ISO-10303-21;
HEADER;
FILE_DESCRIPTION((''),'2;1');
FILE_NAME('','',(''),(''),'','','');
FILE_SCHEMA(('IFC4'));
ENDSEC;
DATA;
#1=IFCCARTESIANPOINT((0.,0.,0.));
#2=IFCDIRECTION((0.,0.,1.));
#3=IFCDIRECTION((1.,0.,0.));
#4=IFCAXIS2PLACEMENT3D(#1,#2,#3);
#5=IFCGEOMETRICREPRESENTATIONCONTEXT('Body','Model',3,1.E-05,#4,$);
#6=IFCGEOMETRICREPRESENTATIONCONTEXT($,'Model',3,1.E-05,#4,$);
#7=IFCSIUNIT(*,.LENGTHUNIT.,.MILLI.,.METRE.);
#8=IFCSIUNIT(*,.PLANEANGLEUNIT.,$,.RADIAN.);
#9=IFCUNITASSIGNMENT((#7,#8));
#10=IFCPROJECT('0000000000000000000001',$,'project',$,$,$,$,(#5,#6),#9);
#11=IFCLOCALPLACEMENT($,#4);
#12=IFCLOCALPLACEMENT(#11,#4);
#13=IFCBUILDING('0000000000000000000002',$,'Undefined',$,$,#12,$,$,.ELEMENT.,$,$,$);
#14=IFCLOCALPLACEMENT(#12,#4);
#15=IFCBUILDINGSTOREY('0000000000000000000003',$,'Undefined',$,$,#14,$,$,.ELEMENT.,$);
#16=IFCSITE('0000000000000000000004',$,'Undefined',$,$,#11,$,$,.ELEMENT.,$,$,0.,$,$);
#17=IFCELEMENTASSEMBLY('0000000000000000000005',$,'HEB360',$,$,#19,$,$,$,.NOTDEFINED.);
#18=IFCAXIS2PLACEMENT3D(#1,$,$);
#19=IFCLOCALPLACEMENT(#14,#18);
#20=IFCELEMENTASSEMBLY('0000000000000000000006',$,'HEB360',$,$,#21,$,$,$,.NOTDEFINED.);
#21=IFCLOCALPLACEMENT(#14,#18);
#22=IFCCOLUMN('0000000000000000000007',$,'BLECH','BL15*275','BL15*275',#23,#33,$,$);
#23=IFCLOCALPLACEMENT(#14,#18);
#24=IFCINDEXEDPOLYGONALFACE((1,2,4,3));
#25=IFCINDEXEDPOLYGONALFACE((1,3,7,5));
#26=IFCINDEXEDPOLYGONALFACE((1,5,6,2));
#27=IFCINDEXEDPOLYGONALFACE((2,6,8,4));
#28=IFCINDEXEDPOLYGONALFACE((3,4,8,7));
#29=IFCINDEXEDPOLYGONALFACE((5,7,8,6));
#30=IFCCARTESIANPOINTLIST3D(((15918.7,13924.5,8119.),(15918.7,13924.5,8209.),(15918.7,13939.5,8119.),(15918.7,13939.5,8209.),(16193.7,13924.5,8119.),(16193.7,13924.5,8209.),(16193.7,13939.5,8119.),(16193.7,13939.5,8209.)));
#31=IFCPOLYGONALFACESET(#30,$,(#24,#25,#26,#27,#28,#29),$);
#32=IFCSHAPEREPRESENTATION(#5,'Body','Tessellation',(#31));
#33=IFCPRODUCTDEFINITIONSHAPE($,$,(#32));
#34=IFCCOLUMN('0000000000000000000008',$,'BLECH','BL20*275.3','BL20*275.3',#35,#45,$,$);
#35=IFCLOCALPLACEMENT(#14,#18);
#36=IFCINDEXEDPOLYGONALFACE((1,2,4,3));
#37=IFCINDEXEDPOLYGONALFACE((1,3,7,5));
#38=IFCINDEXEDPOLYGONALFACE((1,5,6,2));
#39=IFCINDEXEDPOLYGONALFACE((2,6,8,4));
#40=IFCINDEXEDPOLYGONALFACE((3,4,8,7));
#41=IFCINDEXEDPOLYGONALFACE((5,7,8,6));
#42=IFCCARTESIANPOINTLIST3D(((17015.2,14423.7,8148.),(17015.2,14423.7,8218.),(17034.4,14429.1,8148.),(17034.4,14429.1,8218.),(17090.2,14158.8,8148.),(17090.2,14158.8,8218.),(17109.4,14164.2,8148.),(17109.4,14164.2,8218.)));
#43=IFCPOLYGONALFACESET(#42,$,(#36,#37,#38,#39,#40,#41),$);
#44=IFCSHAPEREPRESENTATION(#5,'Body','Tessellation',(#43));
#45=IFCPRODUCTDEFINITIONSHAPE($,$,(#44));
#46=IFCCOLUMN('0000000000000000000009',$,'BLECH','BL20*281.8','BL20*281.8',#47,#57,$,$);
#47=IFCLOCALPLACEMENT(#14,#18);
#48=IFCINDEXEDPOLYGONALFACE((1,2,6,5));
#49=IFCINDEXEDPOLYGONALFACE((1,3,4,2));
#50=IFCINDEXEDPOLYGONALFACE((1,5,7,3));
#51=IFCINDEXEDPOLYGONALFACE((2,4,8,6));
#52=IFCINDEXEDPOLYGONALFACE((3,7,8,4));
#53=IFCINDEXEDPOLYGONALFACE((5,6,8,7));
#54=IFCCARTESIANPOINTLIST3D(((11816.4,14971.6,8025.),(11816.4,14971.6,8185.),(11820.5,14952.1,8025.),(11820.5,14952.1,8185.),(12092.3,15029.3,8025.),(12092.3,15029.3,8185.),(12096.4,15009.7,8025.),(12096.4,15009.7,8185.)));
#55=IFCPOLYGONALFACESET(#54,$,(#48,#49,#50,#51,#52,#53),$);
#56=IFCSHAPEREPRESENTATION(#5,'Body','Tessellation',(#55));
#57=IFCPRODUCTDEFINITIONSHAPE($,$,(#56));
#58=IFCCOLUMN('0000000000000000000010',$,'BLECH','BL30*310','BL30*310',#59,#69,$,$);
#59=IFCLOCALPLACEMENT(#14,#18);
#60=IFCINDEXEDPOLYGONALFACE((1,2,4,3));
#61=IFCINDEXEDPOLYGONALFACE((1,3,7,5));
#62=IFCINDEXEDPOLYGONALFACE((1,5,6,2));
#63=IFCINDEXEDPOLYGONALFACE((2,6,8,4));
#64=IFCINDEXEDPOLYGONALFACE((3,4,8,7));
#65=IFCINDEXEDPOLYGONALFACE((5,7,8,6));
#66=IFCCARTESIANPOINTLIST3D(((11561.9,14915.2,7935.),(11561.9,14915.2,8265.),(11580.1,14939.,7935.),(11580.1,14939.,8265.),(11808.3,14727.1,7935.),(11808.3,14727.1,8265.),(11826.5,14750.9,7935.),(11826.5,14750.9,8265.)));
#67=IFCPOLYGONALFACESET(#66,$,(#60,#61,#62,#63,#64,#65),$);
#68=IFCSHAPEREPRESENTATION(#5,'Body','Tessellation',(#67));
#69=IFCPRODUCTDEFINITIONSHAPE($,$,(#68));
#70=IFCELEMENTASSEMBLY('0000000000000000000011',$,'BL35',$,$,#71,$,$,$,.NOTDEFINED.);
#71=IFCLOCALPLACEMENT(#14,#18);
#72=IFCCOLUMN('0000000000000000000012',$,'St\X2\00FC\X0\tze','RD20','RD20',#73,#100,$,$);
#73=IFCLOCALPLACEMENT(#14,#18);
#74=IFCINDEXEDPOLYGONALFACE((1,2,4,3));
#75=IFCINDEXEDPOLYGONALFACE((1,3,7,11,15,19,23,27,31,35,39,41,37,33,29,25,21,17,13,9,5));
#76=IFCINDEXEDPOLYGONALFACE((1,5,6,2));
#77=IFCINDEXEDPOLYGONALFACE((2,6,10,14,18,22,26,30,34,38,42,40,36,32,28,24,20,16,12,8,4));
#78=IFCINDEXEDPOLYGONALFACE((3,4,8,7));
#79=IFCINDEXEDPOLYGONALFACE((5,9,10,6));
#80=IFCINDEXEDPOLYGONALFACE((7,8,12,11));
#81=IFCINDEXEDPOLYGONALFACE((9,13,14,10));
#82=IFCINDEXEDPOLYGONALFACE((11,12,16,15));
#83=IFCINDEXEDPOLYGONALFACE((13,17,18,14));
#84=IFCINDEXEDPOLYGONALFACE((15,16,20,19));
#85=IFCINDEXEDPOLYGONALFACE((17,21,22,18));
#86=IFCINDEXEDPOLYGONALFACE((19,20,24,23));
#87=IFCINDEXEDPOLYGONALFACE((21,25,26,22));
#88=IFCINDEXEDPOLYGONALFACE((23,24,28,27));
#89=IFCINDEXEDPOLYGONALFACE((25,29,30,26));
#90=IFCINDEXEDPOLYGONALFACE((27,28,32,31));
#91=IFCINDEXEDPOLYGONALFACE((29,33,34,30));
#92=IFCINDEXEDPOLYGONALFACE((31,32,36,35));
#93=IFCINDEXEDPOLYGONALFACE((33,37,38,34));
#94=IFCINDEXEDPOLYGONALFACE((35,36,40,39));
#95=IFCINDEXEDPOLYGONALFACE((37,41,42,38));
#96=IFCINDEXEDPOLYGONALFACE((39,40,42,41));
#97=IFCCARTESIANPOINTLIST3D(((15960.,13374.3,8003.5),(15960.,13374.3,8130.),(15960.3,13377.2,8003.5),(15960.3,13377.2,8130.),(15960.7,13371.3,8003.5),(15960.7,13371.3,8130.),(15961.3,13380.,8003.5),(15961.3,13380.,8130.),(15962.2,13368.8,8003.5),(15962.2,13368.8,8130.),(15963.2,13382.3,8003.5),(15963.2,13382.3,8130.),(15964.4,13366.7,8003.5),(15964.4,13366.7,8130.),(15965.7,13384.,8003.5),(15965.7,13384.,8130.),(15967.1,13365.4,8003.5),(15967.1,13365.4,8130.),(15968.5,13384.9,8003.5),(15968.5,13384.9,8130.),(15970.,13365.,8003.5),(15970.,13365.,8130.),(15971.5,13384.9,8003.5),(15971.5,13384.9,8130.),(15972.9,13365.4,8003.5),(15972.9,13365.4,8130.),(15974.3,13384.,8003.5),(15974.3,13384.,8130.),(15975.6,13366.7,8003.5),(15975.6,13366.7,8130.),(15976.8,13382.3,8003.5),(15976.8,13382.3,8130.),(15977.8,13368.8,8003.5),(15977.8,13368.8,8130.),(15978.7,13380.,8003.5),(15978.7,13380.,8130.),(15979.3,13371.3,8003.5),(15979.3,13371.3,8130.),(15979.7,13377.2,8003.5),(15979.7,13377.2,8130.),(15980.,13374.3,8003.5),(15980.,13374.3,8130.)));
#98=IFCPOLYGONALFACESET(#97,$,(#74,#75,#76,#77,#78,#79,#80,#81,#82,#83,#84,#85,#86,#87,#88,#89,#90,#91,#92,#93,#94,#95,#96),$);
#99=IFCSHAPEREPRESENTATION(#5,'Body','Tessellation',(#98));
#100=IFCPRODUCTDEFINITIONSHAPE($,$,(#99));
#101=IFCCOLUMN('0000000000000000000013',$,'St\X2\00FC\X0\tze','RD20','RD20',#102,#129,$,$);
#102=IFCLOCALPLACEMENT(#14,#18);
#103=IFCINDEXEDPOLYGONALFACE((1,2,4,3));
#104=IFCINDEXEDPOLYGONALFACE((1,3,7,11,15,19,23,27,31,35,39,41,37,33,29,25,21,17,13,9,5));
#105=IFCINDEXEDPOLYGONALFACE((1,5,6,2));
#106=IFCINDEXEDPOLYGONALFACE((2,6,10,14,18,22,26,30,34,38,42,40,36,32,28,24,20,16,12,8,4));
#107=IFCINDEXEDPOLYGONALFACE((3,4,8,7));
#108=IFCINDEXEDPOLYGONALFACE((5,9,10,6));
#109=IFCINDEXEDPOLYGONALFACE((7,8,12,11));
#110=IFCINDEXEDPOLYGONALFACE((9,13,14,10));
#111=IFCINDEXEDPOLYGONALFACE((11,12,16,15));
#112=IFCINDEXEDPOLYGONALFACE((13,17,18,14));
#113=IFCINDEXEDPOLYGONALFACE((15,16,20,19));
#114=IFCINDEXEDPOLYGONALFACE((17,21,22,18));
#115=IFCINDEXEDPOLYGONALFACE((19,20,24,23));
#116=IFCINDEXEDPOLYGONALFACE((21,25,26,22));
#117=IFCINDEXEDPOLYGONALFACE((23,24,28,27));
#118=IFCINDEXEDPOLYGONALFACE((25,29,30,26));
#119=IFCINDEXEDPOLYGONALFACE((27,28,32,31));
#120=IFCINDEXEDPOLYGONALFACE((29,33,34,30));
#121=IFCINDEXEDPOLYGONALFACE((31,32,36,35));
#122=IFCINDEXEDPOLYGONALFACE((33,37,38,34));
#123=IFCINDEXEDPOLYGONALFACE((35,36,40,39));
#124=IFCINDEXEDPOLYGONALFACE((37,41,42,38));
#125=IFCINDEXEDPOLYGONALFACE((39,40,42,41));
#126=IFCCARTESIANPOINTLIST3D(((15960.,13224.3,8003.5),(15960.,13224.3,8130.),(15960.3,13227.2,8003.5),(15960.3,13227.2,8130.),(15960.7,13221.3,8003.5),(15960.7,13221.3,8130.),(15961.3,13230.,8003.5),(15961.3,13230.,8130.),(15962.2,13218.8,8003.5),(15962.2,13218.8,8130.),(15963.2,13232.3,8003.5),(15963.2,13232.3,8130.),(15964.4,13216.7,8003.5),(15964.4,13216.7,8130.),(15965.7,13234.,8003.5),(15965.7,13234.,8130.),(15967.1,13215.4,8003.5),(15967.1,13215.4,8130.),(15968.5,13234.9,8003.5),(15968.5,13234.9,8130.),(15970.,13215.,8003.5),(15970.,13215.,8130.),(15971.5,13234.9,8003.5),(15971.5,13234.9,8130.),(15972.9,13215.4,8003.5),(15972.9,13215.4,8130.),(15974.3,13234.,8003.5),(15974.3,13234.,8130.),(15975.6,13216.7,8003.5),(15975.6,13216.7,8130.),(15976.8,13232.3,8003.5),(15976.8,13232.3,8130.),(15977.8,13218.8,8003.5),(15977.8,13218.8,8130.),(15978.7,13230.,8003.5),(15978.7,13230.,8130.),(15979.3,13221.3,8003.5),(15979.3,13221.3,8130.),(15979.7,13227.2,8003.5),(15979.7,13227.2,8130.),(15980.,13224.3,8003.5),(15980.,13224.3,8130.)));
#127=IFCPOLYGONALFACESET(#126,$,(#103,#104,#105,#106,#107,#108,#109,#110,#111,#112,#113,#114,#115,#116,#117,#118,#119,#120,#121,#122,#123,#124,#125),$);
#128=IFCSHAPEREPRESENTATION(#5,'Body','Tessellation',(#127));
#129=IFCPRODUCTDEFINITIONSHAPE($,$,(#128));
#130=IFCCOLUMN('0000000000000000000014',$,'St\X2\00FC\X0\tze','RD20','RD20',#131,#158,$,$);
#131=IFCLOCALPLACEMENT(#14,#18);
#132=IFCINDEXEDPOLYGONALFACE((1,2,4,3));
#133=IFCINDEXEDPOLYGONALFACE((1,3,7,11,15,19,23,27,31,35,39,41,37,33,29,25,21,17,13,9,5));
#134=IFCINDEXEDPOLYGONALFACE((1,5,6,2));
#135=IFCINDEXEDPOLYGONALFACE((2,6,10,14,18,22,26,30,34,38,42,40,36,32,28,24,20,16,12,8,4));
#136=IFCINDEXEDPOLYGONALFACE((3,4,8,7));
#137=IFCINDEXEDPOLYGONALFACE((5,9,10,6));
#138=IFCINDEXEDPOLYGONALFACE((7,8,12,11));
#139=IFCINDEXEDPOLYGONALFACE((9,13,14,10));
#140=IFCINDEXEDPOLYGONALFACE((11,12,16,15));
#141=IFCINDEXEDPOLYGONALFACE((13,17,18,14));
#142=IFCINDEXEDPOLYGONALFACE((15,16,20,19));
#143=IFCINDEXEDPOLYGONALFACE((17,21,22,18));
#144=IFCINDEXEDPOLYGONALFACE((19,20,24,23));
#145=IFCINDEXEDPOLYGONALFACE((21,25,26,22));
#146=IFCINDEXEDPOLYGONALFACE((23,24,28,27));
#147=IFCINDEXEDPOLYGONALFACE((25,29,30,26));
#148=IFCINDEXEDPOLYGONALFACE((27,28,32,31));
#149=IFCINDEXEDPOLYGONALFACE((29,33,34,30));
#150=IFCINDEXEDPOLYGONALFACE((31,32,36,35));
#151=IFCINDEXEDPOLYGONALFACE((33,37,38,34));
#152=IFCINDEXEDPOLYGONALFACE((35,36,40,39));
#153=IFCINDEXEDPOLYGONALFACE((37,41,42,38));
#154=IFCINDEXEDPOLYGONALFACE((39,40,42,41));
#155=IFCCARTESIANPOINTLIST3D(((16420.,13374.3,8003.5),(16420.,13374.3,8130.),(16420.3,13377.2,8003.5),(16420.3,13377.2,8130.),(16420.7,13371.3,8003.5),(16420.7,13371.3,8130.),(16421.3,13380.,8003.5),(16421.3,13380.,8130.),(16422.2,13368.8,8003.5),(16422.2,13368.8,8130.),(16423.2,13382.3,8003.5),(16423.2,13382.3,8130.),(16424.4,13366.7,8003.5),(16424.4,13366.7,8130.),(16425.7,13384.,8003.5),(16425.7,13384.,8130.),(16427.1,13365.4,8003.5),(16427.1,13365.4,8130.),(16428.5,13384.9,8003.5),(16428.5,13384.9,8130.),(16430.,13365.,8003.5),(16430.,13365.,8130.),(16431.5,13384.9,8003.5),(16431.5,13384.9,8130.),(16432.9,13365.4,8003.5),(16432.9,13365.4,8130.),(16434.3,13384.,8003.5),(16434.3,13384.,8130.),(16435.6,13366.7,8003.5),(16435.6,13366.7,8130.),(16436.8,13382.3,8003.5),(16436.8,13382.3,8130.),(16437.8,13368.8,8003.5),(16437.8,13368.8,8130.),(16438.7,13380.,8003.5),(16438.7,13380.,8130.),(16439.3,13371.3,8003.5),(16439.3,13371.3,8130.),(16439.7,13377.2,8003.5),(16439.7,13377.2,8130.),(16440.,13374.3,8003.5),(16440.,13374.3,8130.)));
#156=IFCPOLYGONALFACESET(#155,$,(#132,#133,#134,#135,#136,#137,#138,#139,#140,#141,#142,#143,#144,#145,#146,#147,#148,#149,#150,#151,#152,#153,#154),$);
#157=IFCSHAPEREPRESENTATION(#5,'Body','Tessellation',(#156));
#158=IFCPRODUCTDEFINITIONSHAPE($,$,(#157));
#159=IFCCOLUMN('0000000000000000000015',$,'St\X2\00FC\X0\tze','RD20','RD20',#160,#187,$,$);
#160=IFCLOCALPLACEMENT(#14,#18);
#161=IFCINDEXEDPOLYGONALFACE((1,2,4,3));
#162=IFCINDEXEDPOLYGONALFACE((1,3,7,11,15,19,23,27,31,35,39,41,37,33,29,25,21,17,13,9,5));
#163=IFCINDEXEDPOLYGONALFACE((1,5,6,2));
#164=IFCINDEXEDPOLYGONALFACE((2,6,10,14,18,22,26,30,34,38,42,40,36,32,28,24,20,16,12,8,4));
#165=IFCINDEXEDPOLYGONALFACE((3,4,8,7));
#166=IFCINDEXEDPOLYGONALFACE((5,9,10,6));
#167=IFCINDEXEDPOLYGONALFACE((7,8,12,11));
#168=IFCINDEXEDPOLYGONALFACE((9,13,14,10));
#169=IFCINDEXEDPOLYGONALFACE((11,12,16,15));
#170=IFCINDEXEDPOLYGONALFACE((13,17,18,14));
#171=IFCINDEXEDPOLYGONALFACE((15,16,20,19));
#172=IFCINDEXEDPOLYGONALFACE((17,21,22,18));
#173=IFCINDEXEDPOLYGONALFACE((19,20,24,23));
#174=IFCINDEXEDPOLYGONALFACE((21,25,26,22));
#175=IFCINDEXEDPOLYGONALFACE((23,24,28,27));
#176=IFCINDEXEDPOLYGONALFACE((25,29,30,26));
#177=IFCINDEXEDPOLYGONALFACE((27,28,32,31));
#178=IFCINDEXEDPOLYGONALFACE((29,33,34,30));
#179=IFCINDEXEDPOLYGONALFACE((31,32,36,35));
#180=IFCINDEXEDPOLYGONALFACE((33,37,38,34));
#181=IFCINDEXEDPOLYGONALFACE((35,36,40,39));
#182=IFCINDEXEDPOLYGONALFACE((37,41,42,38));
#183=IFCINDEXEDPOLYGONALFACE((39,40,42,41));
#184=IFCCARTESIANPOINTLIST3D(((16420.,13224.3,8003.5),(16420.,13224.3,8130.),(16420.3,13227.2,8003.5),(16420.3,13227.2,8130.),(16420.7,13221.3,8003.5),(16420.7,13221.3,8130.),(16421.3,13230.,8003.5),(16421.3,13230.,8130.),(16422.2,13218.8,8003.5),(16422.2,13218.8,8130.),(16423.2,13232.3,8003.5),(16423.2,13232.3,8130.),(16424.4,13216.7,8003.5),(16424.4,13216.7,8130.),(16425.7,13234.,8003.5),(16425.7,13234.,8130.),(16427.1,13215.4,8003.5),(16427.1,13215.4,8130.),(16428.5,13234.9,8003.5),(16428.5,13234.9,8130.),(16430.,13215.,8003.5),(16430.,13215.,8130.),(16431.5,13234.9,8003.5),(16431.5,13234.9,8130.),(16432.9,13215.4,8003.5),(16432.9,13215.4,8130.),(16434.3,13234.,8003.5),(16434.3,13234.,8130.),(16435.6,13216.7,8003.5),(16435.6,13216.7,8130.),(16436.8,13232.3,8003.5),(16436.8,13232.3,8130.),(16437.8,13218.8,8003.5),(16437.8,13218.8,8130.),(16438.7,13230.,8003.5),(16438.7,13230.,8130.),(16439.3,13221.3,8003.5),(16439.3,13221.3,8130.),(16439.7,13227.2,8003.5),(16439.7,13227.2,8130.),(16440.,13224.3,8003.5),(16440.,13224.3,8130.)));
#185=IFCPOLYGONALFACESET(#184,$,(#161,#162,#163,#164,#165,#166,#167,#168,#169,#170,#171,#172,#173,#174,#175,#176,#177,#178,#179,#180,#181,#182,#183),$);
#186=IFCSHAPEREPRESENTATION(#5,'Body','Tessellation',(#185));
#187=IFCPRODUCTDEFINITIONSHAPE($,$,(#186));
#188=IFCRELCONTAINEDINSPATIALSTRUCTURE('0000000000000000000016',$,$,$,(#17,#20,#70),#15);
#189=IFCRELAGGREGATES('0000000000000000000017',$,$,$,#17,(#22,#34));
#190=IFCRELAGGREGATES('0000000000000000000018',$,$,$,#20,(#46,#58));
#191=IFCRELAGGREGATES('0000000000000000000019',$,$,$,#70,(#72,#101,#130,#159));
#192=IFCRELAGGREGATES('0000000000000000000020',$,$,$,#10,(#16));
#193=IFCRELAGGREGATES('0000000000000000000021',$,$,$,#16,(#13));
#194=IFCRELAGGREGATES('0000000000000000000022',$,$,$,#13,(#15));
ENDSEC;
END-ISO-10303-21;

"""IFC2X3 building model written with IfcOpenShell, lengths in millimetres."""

from ifc_helpers import new_model, si_unit, frame, origin_with_axes, origin_2d_with_axis, place, context, project, spatial, rectangle, circle, extrude, element, aggregate, save


model = new_model("IFC2X3")

# Units and contexts
model_context_1 = context("Model", 3, precision=1e-05, world=origin_with_axes(), identifier="Body")
model_context_2 = context("Model", 3, precision=1e-05, world=origin_with_axes())
ifc_project = project(units=[si_unit("LENGTHUNIT", "METRE", prefix="MILLI"), si_unit("PLANEANGLEUNIT", "RADIAN")], contexts=[model_context_1, model_context_2])

# Site, building, storey
site_placement = place(None, origin_with_axes())
site = spatial("IfcSite", under=ifc_project, at=site_placement, Name="Undefined", CompositionType="ELEMENT", RefElevation=0.0)
building_placement = place(site_placement, origin_with_axes())
building = spatial("IfcBuilding", under=site, at=building_placement, Name="Undefined", CompositionType="ELEMENT")
storey_placement = place(building_placement, origin_with_axes())
storey = spatial("IfcBuildingStorey", under=building, at=storey_placement, Name="Undefined", CompositionType="ELEMENT")

# Element assembly
assembly_1 = element("IfcElementAssembly", 1, inside=storey, Name="HEB360", PredefinedType="NOTDEFINED")

# Element assembly
assembly_2 = element("IfcElementAssembly", 2, inside=storey, Name="HEB360", PredefinedType="NOTDEFINED")

# Columns
column_1_placement = place(storey_placement, frame((16056.2, 13932.0, 8119.0), z_axis=(0.0, 0.0, 1.0), x_axis=(1.0, 0.0, 0.0)))
column_1 = element("IfcColumn", 3, at=column_1_placement, Name="BLECH", Description="BL15*275", ObjectType="BL15*275", context=model_context_1, shape_type="SweptSolid", body=[
    extrude(rectangle(XDim=15.0, YDim=275.0, at=origin_2d_with_axis()), frame((0.0, 0.0, 90.0), z_axis=(0.0, 0.0, -1.0), x_axis=(0.0, 1.0, 0.0)), (0.0, 0.0, 1.0), 90.0),
])
column_2_placement = place(storey_placement, frame((17062.3, 14294.0, 8148.0), z_axis=(0.0, 0.0, 1.0), x_axis=(1.0, 0.0, 0.0)))
column_2 = element("IfcColumn", 4, at=column_2_placement, Name="BLECH", Description="BL20*275.3", ObjectType="BL20*275.3", context=model_context_1, shape_type="SweptSolid", body=[
    extrude(rectangle(XDim=20.0, YDim=275.3, at=origin_2d_with_axis()), frame((0.0, 0.0, 70.0), z_axis=(0.0, 0.0, -1.0), x_axis=(0.96217, 0.272448, 0.0)), (0.0, 0.0, 1.0), 70.0),
])
aggregate(assembly_1, [column_1, column_2])
column_3_placement = place(storey_placement, frame((11956.4, 14990.7, 8025.0), z_axis=(0.0, 0.0, 1.0), x_axis=(1.0, 0.0, 0.0)))
column_3 = element("IfcColumn", 5, at=column_3_placement, Name="BLECH", Description="BL20*281.8", ObjectType="BL20*281.8", context=model_context_1, shape_type="SweptSolid", body=[
    extrude(rectangle(XDim=20.0, YDim=281.8, at=origin_2d_with_axis()), frame((0.0, 0.0, 160.0), z_axis=(0.0, 0.0, -1.0), x_axis=(0.204666, -0.978832, 0.0)), (0.0, 0.0, 1.0), 160.0),
])
column_4_placement = place(storey_placement, frame((11694.2, 14833.1, 7935.0), z_axis=(0.0, 0.0, 1.0), x_axis=(1.0, 0.0, 0.0)))
column_4 = element("IfcColumn", 6, at=column_4_placement, Name="BLECH", Description="BL30*310", ObjectType="BL30*310", context=model_context_1, shape_type="SweptSolid", body=[
    extrude(rectangle(XDim=30.0, YDim=310.0, at=origin_2d_with_axis()), frame((0.0, 0.0, 330.0), z_axis=(0.0, 0.0, -1.0), x_axis=(-0.606842, -0.794823, 0.0)), (0.0, 0.0, 1.0), 330.0),
])
aggregate(assembly_2, [column_3, column_4])

# Element assembly, columns
assembly_3 = element("IfcElementAssembly", 7, inside=storey, Name="BL35", PredefinedType="NOTDEFINED")
column_5_placement = place(storey_placement, frame((15970.0, 13375.0, 8003.5), z_axis=(0.0, 0.0, 1.0), x_axis=(1.0, 0.0, 0.0)))
column_5 = element("IfcColumn", 8, at=column_5_placement, Name="Stütze", Description="RD20", ObjectType="RD20", context=model_context_1, shape_type="SweptSolid", body=[
    extrude(circle(Radius=10.0, at=origin_2d_with_axis()), frame((0.0, 0.0, 126.5), z_axis=(0.0, 0.0, -1.0), x_axis=(0.0, -1.0, 0.0)), (0.0, 0.0, 1.0), 126.5),
])
column_6_placement = place(storey_placement, frame((15970.0, 13225.0, 8003.5), z_axis=(0.0, 0.0, 1.0), x_axis=(1.0, 0.0, 0.0)))
column_6 = element("IfcColumn", 9, at=column_6_placement, Name="Stütze", Description="RD20", ObjectType="RD20", context=model_context_1, shape_type="SweptSolid", body=[
    extrude(circle(Radius=10.0, at=origin_2d_with_axis()), frame((0.0, 0.0, 126.5), z_axis=(0.0, 0.0, -1.0), x_axis=(0.0, -1.0, 0.0)), (0.0, 0.0, 1.0), 126.5),
])
column_7_placement = place(storey_placement, frame((16430.0, 13375.0, 8003.5), z_axis=(0.0, 0.0, 1.0), x_axis=(1.0, 0.0, 0.0)))
column_7 = element("IfcColumn", 10, at=column_7_placement, Name="Stütze", Description="RD20", ObjectType="RD20", context=model_context_1, shape_type="SweptSolid", body=[
    extrude(circle(Radius=10.0, at=origin_2d_with_axis()), frame((0.0, 0.0, 126.5), z_axis=(0.0, 0.0, -1.0), x_axis=(0.0, -1.0, 0.0)), (0.0, 0.0, 1.0), 126.5),
])
column_8_placement = place(storey_placement, frame((16430.0, 13225.0, 8003.5), z_axis=(0.0, 0.0, 1.0), x_axis=(1.0, 0.0, 0.0)))
column_8 = element("IfcColumn", 11, at=column_8_placement, Name="Stütze", Description="RD20", ObjectType="RD20", context=model_context_1, shape_type="SweptSolid", body=[
    extrude(circle(Radius=10.0, at=origin_2d_with_axis()), frame((0.0, 0.0, 126.5), z_axis=(0.0, 0.0, -1.0), x_axis=(0.0, -1.0, 0.0)), (0.0, 0.0, 1.0), 126.5),
])
aggregate(assembly_3, [column_5, column_6, column_7, column_8])

save(model, "model.ifc")
